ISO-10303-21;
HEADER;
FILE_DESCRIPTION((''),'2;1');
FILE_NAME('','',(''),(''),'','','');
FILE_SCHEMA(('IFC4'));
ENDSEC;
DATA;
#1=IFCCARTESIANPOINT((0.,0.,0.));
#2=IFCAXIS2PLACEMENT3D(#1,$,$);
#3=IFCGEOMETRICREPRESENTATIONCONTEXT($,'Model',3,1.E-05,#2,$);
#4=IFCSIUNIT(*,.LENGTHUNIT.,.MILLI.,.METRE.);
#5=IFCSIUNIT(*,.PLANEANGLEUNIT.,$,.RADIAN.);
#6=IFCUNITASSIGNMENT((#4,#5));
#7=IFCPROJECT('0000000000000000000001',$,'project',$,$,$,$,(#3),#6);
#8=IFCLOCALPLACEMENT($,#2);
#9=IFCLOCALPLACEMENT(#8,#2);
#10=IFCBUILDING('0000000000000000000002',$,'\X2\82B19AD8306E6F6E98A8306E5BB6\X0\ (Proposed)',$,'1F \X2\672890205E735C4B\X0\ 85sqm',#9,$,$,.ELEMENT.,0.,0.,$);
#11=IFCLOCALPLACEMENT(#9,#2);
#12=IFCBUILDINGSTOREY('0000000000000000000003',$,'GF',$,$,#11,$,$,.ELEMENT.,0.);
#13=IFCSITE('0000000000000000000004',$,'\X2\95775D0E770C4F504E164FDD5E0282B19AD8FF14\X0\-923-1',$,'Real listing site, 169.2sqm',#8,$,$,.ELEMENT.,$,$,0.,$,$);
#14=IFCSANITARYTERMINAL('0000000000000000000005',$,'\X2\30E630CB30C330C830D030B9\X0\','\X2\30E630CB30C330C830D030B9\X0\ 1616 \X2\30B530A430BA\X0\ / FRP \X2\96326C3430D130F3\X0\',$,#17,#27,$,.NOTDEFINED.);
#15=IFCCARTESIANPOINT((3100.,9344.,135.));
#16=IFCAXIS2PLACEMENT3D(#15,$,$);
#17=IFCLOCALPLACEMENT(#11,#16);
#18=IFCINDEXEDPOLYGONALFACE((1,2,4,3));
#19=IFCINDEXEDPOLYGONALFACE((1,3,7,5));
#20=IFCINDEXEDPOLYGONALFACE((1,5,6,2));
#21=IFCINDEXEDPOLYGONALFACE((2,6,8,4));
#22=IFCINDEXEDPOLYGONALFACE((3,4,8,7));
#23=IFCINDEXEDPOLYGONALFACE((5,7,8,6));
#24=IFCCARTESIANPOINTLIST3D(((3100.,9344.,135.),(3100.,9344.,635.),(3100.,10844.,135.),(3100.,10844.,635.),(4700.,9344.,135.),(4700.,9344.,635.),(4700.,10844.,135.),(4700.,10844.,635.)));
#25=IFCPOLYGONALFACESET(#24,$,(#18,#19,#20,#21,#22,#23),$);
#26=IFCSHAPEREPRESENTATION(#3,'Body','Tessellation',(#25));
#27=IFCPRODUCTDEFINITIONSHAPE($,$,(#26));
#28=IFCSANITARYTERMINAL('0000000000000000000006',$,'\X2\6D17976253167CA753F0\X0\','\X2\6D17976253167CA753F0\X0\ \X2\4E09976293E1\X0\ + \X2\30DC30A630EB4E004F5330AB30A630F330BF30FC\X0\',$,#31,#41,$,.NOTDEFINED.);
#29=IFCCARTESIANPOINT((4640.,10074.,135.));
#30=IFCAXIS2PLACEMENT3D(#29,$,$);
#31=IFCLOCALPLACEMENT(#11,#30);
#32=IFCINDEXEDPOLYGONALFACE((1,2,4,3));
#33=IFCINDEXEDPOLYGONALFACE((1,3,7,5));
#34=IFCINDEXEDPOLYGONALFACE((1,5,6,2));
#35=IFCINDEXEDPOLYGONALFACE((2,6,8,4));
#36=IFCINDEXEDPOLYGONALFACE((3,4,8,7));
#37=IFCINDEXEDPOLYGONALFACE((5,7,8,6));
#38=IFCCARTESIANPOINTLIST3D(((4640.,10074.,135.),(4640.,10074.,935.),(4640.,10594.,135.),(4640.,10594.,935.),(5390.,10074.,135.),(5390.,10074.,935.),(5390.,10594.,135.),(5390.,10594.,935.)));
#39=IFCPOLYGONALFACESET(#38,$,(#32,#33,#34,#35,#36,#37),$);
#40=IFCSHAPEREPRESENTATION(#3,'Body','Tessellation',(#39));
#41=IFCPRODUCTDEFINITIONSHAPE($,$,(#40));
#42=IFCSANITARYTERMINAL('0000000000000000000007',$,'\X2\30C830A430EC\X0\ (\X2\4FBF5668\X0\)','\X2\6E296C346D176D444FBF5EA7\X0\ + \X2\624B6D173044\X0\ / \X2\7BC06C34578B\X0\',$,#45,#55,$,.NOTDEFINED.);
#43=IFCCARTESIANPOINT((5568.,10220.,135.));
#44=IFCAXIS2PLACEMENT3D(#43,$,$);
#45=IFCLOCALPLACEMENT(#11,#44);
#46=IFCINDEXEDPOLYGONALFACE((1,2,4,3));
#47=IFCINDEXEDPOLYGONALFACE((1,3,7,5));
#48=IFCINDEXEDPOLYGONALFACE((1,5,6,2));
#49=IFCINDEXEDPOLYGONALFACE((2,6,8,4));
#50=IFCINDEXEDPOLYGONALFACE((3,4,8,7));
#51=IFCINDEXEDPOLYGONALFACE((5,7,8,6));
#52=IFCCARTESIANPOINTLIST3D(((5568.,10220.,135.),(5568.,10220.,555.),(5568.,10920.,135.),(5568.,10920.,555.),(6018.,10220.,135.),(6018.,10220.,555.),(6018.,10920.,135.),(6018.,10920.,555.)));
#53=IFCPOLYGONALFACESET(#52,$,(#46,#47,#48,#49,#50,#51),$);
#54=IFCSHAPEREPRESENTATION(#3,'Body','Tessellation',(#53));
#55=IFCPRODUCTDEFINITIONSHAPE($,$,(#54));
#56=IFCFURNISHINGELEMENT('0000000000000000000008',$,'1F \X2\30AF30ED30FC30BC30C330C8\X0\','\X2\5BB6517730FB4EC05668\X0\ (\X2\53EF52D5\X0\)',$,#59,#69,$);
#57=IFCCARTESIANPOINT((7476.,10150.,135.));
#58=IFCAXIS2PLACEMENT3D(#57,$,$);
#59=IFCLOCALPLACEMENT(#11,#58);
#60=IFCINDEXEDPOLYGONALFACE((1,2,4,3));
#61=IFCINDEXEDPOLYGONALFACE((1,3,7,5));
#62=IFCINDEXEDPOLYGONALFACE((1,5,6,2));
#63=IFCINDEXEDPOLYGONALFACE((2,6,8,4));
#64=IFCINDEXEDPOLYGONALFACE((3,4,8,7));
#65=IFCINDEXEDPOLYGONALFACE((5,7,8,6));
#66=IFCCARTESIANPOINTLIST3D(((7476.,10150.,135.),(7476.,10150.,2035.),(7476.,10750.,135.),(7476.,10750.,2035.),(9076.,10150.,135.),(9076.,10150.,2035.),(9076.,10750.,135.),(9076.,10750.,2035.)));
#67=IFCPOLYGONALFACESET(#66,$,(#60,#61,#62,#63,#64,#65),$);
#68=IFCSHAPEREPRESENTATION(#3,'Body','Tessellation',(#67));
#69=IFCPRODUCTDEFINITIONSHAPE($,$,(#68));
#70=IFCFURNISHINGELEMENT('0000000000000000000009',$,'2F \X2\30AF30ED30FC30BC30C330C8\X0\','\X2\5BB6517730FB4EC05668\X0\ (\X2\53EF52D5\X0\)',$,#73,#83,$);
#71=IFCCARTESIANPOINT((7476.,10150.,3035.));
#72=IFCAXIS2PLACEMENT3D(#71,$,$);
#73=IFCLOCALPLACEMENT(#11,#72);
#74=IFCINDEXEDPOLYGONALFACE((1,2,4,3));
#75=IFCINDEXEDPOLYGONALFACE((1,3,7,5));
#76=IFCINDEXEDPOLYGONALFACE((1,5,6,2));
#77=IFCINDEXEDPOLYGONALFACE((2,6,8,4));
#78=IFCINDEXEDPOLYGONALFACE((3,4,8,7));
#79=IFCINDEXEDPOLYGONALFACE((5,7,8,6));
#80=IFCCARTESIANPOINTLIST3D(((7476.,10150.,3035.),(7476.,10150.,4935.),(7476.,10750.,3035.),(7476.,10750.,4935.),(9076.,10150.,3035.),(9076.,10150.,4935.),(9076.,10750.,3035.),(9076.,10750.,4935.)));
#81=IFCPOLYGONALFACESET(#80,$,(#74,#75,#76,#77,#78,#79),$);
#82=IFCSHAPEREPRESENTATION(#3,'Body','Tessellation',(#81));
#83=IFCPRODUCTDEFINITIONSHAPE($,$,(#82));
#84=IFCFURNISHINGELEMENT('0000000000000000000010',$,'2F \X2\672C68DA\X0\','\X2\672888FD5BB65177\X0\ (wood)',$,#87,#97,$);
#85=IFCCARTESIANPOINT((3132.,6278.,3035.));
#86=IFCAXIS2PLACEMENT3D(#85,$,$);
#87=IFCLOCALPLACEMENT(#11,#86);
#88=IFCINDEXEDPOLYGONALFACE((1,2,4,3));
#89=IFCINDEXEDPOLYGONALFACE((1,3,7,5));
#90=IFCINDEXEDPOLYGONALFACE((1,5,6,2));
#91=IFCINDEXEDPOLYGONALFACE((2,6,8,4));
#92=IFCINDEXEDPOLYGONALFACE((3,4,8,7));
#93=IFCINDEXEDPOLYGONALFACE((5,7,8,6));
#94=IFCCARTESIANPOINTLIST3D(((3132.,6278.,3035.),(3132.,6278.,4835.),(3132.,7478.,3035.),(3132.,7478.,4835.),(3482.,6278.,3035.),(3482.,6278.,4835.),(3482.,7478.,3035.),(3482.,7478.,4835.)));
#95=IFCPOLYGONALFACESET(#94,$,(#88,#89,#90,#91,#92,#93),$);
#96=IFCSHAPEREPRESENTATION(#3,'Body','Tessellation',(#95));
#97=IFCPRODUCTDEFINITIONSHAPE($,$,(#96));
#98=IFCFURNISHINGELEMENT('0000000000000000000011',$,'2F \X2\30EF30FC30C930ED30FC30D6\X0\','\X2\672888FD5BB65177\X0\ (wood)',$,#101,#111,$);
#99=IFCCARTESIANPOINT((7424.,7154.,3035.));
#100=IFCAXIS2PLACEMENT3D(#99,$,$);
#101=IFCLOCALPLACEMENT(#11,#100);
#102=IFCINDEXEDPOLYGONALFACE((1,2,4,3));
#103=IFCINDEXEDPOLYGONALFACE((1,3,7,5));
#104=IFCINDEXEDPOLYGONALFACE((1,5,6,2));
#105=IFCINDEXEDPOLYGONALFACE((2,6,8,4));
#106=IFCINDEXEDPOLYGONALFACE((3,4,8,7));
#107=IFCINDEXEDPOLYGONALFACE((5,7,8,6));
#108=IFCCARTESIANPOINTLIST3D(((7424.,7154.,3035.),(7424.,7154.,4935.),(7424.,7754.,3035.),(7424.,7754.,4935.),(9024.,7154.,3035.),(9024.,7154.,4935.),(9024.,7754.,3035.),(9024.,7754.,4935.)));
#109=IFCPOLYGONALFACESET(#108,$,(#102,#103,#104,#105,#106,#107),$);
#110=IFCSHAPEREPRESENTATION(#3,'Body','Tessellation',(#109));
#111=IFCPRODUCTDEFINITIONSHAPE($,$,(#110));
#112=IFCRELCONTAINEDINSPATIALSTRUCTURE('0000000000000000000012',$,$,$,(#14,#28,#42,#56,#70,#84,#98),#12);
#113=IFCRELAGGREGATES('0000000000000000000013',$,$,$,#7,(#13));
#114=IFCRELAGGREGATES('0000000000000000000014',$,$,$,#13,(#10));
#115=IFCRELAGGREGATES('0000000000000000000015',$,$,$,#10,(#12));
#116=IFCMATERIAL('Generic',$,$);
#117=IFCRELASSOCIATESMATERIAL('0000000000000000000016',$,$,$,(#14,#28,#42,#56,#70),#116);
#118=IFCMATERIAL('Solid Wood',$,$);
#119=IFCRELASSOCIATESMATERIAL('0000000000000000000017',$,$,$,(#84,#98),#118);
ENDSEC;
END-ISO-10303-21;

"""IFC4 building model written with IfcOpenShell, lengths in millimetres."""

from ifc_helpers import new_model, si_unit, frame, frame_2d, origin, place, context, project, spatial, rectangle, extrude, material, element, save


model = new_model("IFC4")

# Units and contexts
model_context = context("Model", 3, precision=1e-05, world=origin())
ifc_project = project(units=[si_unit("LENGTHUNIT", "METRE", prefix="MILLI"), si_unit("PLANEANGLEUNIT", "RADIAN")], contexts=[model_context])

# Site, building, storey
site_placement = place(None, origin())
site = spatial("IfcSite", under=ifc_project, at=site_placement, Name="長崎県佐世保市花高４-923-1", ObjectType="Real listing site, 169.2sqm", CompositionType="ELEMENT", RefElevation=0.0)
building_placement = place(site_placement, origin())
building = spatial("IfcBuilding", under=site, at=building_placement, Name="花高の潮風の家 (Proposed)", ObjectType="1F 木造平屋 85sqm", CompositionType="ELEMENT", ElevationOfRefHeight=0.0, ElevationOfTerrain=0.0)
storey_placement = place(building_placement, origin())
storey = spatial("IfcBuildingStorey", under=building, at=storey_placement, Name="GF", CompositionType="ELEMENT", Elevation=0.0)

# Shared definitions
ifc_material_1 = material(Name="Solid Wood")

# Shared definitions
ifc_material_2 = material(Name="Generic")

# Sanitary terminals
sanitary_terminal_1_placement = place(storey_placement, frame((3100.0, 9344.0, 135.0)))
element("IfcSanitaryTerminal", 1, at=sanitary_terminal_1_placement, inside=storey, material=ifc_material_2, Name="ユニットバス", Description="ユニットバス 1616 サイズ / FRP 防水パン", PredefinedType="NOTDEFINED", context=model_context, shape_type="SweptSolid", body=[
    extrude(rectangle(XDim=1600.0, YDim=1500.0, at=frame_2d((800.0, 750.0))), frame((3100.0, 9344.0, 135.0)), (0.0, 0.0, 1.0), 500.0),
])
sanitary_terminal_2_placement = place(storey_placement, frame((4640.0, 10074.0, 135.0)))
element("IfcSanitaryTerminal", 2, at=sanitary_terminal_2_placement, inside=storey, material=ifc_material_2, Name="洗面化粧台", Description="洗面化粧台 三面鏡 + ボウル一体カウンター", PredefinedType="NOTDEFINED", context=model_context, shape_type="SweptSolid", body=[
    extrude(rectangle(XDim=750.0, YDim=520.0, at=frame_2d((375.0, 260.0))), frame((4640.0, 10074.0, 135.0)), (0.0, 0.0, 1.0), 800.0),
])
sanitary_terminal_3_placement = place(storey_placement, frame((5568.0, 10220.0, 135.0)))
element("IfcSanitaryTerminal", 3, at=sanitary_terminal_3_placement, inside=storey, material=ifc_material_2, Name="トイレ (便器)", Description="温水洗浄便座 + 手洗い / 節水型", PredefinedType="NOTDEFINED", context=model_context, shape_type="SweptSolid", body=[
    extrude(rectangle(XDim=450.0, YDim=700.0, at=frame_2d((225.0, 350.0))), frame((5568.0, 10220.0, 135.0)), (0.0, 0.0, 1.0), 420.0),
])

# Furnishing elements
furnishing_1_placement = place(storey_placement, frame((7476.0, 10150.0, 135.0)))
element("IfcFurnishingElement", 4, at=furnishing_1_placement, inside=storey, material=ifc_material_2, Name="1F クローゼット", Description="家具・什器 (可動)", context=model_context, shape_type="SweptSolid", body=[
    extrude(rectangle(XDim=1600.0, YDim=600.0, at=frame_2d((800.0, 300.0))), frame((7476.0, 10150.0, 135.0)), (0.0, 0.0, 1.0), 1900.0),
])
furnishing_2_placement = place(storey_placement, frame((7476.0, 10150.0, 3035.0)))
element("IfcFurnishingElement", 5, at=furnishing_2_placement, inside=storey, material=ifc_material_2, Name="2F クローゼット", Description="家具・什器 (可動)", context=model_context, shape_type="SweptSolid", body=[
    extrude(rectangle(XDim=1600.0, YDim=600.0, at=frame_2d((800.0, 300.0))), frame((7476.0, 10150.0, 3035.0)), (0.0, 0.0, 1.0), 1900.0),
])
furnishing_3_placement = place(storey_placement, frame((3132.0, 6278.0, 3035.0)))
element("IfcFurnishingElement", 6, at=furnishing_3_placement, inside=storey, material=ifc_material_1, Name="2F 本棚", Description="木製家具 (wood)", context=model_context, shape_type="SweptSolid", body=[
    extrude(rectangle(XDim=350.0, YDim=1200.0, at=frame_2d((175.0, 600.0))), frame((3132.0, 6278.0, 3035.0)), (0.0, 0.0, 1.0), 1800.0),
])
furnishing_4_placement = place(storey_placement, frame((7424.0, 7154.0, 3035.0)))
element("IfcFurnishingElement", 7, at=furnishing_4_placement, inside=storey, material=ifc_material_1, Name="2F ワードローブ", Description="木製家具 (wood)", context=model_context, shape_type="SweptSolid", body=[
    extrude(rectangle(XDim=1600.0, YDim=600.0, at=frame_2d((800.0, 300.0))), frame((7424.0, 7154.0, 3035.0)), (0.0, 0.0, 1.0), 1900.0),
])

save(model, "model.ifc")
